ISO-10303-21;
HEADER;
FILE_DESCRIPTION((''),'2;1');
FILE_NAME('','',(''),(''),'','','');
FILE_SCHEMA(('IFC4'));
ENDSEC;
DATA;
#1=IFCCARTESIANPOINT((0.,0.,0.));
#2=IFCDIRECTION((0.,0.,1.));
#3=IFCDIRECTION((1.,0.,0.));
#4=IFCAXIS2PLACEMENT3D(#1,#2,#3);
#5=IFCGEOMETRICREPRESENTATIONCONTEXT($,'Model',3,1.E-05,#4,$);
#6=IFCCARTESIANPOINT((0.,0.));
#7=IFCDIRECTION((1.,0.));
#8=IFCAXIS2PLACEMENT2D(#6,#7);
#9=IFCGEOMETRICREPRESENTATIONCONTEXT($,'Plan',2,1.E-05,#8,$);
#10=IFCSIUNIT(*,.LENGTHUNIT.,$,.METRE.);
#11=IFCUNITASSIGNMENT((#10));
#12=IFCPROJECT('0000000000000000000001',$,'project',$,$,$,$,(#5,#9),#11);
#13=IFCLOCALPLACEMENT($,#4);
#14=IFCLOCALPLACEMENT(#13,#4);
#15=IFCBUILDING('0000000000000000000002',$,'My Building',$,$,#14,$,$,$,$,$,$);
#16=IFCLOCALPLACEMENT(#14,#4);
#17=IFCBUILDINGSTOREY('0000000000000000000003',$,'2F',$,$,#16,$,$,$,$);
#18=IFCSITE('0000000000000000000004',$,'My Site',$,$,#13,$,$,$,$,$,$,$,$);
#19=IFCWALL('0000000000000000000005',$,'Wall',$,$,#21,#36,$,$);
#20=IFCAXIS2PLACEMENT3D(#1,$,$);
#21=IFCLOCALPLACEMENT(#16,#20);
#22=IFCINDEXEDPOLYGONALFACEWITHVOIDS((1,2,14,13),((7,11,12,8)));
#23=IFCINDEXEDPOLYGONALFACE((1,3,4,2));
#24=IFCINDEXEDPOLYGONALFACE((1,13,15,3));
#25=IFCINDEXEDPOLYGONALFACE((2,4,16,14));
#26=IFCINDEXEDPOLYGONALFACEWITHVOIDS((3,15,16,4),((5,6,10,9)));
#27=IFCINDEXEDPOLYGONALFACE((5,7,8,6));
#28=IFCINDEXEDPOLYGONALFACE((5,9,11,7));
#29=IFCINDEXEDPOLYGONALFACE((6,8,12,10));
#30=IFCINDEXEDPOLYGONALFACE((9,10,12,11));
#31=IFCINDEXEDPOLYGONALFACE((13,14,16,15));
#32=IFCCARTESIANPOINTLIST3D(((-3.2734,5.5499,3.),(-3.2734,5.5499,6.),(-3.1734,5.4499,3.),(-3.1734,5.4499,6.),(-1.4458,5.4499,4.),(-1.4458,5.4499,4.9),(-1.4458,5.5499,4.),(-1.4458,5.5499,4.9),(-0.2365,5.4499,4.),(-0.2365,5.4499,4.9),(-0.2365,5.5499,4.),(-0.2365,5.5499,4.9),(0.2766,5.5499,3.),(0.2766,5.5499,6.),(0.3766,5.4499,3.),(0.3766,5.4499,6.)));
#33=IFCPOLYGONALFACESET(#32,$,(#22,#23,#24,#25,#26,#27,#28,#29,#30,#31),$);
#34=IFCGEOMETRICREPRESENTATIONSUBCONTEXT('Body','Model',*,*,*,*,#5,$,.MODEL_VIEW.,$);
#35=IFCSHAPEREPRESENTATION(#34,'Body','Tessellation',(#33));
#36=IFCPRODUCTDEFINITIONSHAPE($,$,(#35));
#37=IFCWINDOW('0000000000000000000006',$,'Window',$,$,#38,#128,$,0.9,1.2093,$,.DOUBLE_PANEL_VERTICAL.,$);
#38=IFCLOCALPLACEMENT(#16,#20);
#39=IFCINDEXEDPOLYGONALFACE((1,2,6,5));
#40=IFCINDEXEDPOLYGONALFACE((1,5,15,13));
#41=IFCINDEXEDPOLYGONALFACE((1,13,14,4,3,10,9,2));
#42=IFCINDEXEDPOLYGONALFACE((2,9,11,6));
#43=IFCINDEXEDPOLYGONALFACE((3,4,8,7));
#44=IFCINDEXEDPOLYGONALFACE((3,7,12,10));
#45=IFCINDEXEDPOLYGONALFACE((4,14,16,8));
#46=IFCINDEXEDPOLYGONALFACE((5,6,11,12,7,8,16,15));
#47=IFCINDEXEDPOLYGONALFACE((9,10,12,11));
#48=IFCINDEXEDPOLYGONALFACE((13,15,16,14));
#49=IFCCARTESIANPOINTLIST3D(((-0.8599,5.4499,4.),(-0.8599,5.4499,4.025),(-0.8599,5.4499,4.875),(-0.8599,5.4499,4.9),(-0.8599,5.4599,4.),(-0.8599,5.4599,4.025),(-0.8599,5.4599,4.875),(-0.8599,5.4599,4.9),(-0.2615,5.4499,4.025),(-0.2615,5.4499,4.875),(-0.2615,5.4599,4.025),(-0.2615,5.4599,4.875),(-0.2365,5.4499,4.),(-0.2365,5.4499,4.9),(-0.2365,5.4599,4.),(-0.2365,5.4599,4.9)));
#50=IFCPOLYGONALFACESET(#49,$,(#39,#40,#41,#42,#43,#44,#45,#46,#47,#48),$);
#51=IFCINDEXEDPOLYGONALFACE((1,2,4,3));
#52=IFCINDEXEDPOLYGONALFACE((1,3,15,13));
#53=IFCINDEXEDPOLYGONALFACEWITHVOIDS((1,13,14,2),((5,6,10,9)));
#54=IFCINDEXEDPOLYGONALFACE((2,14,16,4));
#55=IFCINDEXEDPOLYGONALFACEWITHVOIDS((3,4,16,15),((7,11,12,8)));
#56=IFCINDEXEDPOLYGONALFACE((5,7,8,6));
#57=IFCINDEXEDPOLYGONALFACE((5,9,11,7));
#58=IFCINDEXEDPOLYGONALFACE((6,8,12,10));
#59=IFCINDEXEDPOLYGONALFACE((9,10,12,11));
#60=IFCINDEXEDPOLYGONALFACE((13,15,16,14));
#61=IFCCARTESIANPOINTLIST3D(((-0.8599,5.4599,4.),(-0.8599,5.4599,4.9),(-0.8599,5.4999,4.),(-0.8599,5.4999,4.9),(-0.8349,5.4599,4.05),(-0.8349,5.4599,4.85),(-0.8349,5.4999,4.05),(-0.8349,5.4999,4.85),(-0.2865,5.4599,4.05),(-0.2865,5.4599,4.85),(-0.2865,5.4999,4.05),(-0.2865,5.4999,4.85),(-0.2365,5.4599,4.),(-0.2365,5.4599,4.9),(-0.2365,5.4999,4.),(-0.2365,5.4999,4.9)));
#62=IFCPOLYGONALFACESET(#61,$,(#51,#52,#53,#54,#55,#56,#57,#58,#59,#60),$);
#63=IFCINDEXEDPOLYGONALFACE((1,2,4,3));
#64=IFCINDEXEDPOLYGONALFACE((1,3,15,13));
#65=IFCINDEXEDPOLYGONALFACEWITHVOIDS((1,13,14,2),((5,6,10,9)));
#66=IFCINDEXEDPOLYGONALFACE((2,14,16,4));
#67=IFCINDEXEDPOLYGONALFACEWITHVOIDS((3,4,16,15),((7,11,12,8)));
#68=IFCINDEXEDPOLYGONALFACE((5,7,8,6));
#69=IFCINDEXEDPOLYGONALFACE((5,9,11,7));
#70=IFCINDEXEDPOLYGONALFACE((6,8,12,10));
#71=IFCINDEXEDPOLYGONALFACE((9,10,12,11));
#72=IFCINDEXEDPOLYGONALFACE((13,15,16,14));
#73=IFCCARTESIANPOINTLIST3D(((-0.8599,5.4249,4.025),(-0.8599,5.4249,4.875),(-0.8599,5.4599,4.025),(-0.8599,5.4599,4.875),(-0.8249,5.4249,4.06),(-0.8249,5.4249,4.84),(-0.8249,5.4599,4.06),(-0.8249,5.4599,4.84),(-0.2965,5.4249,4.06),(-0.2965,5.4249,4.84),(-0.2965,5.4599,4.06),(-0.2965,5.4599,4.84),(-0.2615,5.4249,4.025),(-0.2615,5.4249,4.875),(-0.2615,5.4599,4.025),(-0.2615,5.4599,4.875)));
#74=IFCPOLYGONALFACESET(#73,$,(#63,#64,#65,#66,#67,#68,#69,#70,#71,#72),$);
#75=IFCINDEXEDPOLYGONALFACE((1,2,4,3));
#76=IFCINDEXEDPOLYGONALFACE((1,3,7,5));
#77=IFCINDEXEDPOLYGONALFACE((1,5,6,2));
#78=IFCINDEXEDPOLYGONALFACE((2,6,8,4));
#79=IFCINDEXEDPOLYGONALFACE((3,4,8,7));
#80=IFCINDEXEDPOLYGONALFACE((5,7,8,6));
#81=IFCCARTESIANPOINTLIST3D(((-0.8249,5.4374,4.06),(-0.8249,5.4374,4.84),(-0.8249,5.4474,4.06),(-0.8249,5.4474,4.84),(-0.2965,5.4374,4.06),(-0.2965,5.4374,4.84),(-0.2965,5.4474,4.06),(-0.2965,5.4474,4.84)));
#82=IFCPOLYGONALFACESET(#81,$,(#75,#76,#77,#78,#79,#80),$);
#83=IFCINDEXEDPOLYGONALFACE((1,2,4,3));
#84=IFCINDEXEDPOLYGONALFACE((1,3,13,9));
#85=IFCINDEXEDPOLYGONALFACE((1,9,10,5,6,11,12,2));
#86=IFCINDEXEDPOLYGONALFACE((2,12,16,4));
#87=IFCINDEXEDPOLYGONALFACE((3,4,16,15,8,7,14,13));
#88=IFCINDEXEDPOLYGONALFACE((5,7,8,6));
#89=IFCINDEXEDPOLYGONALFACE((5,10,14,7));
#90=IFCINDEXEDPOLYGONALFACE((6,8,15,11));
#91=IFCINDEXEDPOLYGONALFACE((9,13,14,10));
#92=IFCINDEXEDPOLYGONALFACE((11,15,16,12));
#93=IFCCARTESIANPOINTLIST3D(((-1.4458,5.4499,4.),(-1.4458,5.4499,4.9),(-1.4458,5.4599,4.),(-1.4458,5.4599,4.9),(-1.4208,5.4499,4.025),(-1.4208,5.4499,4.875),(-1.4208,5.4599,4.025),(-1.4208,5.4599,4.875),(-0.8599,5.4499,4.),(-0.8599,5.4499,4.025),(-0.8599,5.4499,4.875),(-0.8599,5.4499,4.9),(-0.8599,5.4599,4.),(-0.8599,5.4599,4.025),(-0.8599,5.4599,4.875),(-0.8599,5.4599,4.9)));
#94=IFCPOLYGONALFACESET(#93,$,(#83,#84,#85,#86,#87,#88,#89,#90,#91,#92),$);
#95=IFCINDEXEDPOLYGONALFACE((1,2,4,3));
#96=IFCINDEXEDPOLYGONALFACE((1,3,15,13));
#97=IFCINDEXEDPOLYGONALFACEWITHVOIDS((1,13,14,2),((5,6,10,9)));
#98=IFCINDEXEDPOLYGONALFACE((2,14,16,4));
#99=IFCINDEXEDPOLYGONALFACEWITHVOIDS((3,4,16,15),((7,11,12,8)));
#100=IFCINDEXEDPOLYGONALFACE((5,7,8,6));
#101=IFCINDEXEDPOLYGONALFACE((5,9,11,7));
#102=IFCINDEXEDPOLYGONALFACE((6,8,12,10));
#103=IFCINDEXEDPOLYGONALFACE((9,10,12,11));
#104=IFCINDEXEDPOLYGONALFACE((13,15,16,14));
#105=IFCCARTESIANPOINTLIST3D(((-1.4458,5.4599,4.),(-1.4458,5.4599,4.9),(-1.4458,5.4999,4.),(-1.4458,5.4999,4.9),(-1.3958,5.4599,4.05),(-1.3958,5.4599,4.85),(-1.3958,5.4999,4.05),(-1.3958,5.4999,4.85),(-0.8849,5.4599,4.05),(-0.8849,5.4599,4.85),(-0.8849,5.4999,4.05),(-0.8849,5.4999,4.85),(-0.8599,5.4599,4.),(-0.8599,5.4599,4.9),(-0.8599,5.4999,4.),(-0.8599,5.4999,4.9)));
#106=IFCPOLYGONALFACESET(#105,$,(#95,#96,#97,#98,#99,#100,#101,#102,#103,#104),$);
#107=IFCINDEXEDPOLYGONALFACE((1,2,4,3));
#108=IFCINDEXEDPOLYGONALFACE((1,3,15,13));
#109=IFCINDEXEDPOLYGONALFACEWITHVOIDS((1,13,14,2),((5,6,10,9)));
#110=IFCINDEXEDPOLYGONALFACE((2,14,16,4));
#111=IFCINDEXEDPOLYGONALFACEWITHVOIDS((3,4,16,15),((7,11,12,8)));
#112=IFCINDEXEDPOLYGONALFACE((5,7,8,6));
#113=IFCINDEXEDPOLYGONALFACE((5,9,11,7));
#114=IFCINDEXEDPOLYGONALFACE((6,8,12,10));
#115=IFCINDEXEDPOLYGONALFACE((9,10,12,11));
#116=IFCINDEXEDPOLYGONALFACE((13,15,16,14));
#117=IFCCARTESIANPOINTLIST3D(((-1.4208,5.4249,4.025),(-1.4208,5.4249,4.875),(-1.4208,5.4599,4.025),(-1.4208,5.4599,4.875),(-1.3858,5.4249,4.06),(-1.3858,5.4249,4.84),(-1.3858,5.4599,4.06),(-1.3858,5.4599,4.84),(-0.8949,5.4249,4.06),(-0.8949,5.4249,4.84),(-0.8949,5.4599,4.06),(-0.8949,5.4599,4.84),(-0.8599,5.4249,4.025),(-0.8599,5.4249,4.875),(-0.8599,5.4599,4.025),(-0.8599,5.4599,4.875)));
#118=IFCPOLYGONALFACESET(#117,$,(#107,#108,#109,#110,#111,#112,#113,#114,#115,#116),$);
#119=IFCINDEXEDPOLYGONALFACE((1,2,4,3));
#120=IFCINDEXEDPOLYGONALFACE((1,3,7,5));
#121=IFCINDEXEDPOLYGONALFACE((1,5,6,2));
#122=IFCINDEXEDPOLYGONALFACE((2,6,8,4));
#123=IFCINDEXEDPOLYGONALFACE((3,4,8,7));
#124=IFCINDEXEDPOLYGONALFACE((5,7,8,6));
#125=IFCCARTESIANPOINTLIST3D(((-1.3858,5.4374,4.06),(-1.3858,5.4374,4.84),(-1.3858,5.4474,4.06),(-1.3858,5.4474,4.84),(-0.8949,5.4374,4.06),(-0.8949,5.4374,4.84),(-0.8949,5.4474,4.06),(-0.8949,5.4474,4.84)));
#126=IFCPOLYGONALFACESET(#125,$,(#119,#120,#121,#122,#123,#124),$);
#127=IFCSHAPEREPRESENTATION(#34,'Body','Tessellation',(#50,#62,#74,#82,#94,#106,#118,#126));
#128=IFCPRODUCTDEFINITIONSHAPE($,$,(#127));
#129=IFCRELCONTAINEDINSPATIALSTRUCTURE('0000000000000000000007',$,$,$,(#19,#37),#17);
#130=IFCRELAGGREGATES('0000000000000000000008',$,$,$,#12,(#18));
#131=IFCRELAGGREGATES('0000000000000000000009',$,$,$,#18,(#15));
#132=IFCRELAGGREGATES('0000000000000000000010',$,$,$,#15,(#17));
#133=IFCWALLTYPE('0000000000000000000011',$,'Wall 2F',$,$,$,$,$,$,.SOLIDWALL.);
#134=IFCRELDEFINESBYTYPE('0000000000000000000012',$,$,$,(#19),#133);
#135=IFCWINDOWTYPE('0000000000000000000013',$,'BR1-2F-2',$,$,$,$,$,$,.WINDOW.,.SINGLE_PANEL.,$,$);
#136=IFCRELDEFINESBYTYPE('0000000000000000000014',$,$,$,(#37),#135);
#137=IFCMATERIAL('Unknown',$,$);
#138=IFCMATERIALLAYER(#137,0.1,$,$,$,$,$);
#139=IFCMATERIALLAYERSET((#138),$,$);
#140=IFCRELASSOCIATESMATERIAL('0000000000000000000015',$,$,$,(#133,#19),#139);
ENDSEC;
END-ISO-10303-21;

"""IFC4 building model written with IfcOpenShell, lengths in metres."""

from ifc_helpers import new_model, entity, si_unit, frame, origin_with_axes, origin_2d_with_axis, place, context, subcontext, project, spatial, line, indexed_curve, outline, extrude, shape, source, transform, mapped, material, layer, layer_set, layer_usage, type_object, type_shapes, element, fill, save


model = new_model("IFC4")

# Units and contexts
model_context = context("Model", 3, precision=1e-05, world=origin_with_axes())
plan_context = context("Plan", 2, precision=1e-05, world=origin_2d_with_axis())
body_context_1 = subcontext(model_context, "Body", "Model", "MODEL_VIEW")
body_context_2 = subcontext(plan_context, "Body", "Plan", "PLAN_VIEW")
ifc_project = project(units=[si_unit("LENGTHUNIT", "METRE")], contexts=[model_context, plan_context])

# Site, building, storey
site_placement = place(None, origin_with_axes())
site = spatial("IfcSite", under=ifc_project, at=site_placement, Name="My Site")
building_placement = place(site_placement, origin_with_axes())
building = spatial("IfcBuilding", under=site, at=building_placement, Name="My Building")
storey_placement = place(building_placement, origin_with_axes())
storey = spatial("IfcBuildingStorey", under=building, at=storey_placement, Name="2F")

# Shared definitions
ifc_material = material(Name="Unknown")

# Shared definitions
ifc_layer_1 = layer(ifc_material, 0.1)
ifc_layer_set_1 = layer_set([ifc_layer_1])
wall_type = type_object("IfcWallType", Name="Wall 2F", PredefinedType="SOLIDWALL", material=ifc_layer_set_1)

# Wall, opening, window
ifc_layer_usage_1 = layer_usage(ifc_layer_set_1, "AXIS2", "POSITIVE", 0.0)
wall_1_placement = place(storey_placement, frame((0.2766, 5.5499, 3.0), z_axis=(0.0, 0.0, 1.0), x_axis=(-1.0, 0.0, 0.0)))
wall_1 = element("IfcWall", 1, at=wall_1_placement, inside=storey, type_object=wall_type, material=ifc_layer_usage_1, Name="Wall", context=body_context_1, shape_type="SweptSolid", body=[
    extrude(outline(indexed_curve([(0.0, 0.0), (-0.1, 0.1), (3.45, 0.1), (3.55, 0.0)], segments=[line(1, 2, 3, 4, 1)])), origin_with_axes(), (0.0, 0.0, 1.0), 3.0),
])
shared_shape_1 = source(origin_with_axes(), body_context_1, "Body", "SweptSolid", [
    extrude(outline(indexed_curve([(0.0, 0.0), (1.2093, 0.0), (1.2093, 0.9), (0.0, 0.9)], segments=[line(1, 2, 3, 4, 1)])), frame((0.0, -0.6, 0.0), z_axis=(0.0, -1.0, 0.0), x_axis=(1.0, 0.0, 0.0)), (0.0, 0.0, -1.0), 1.2),
])
opening_1_placement = place(wall_1_placement, frame((0.5131, 0.0, 1.0), z_axis=(0.0, 0.0, 1.0), x_axis=(1.0, 0.0, 0.0)))
opening_1 = element("IfcOpeningElement", 2, at=opening_1_placement, cuts=wall_1, PredefinedType="OPENING", context=body_context_1, shape_type="MappedRepresentation", body=[
    mapped(shared_shape_1, transform((0.0, 0.0, 0.0), x_axis=(1.0, 0.0, 0.0), y_axis=(0.0, 1.0, 0.0), z_axis=(0.0, 0.0, 1.0), scale=1.0)),
])
window_type_1 = type_object("IfcWindowType", Name="BR1-2F-2", PartitioningType="SINGLE_PANEL", PredefinedType="WINDOW")
shared_shape_2 = source(origin_with_axes(), body_context_1, "Body", "SweptSolid", [
    extrude(outline(indexed_curve([(0.6234, 0.0), (0.0, 0.0), (0.0, 0.9), (0.6234, 0.9), (0.6234, 0.875), (0.025, 0.875), (0.025, 0.025), (0.6234, 0.025)], segments=[line(1, 2, 3, 4, 5, 6, 7, 8, 1)])), frame((0.0, 0.09, 0.0), z_axis=(0.0, -1.0, 0.0), x_axis=(1.0, 0.0, 0.0)), (0.0, 0.0, -1.0), 0.01),
    extrude(outline(indexed_curve([(0.0, 0.0), (0.6234, 0.0), (0.6234, 0.9), (0.0, 0.9)], segments=[line(1, 2, 3, 4, 1)]), holes=[indexed_curve([(0.05, 0.05), (0.5984, 0.05), (0.5984, 0.85), (0.05, 0.85)], segments=[line(1, 2, 3, 4, 1)])]), frame((0.0, 0.05, 0.0), z_axis=(0.0, -1.0, 0.0), x_axis=(1.0, 0.0, 0.0)), (0.0, 0.0, -1.0), 0.04),
    extrude(outline(indexed_curve([(0.0, 0.0), (0.5984, 0.0), (0.5984, 0.85), (0.0, 0.85)], segments=[line(1, 2, 3, 4, 1)]), holes=[indexed_curve([(0.035, 0.035), (0.5634, 0.035), (0.5634, 0.815), (0.035, 0.815)], segments=[line(1, 2, 3, 4, 1)])]), frame((0.025, 0.09, 0.025), z_axis=(0.0, -1.0, 0.0), x_axis=(1.0, 0.0, 0.0)), (0.0, 0.0, -1.0), 0.035),
    extrude(outline(indexed_curve([(0.035, 0.035), (0.5634, 0.035), (0.5634, 0.815), (0.035, 0.815)], segments=[line(1, 2, 3, 4, 1)])), frame((0.025, 0.1025, 0.025), z_axis=(0.0, -1.0, 0.0), x_axis=(1.0, 0.0, 0.0)), (0.0, 0.0, -1.0), 0.01),
    extrude(outline(indexed_curve([(0.0, 0.9), (0.5859, 0.9), (0.5859, 0.0), (0.0, 0.0), (0.0, 0.025), (0.5609, 0.025), (0.5609, 0.875), (0.0, 0.875)], segments=[line(1, 2, 3, 4, 5, 6, 7, 8, 1)])), frame((0.6234, 0.09, 0.0), z_axis=(0.0, -1.0, 0.0), x_axis=(1.0, 0.0, 0.0)), (0.0, 0.0, -1.0), 0.01),
    extrude(outline(indexed_curve([(0.0, 0.0), (0.5859, 0.0), (0.5859, 0.9), (0.0, 0.9)], segments=[line(1, 2, 3, 4, 1)]), holes=[indexed_curve([(0.025, 0.05), (0.5359, 0.05), (0.5359, 0.85), (0.025, 0.85)], segments=[line(1, 2, 3, 4, 1)])]), frame((0.6234, 0.05, 0.0), z_axis=(0.0, -1.0, 0.0), x_axis=(1.0, 0.0, 0.0)), (0.0, 0.0, -1.0), 0.04),
    extrude(outline(indexed_curve([(0.0, 0.0), (0.5609, 0.0), (0.5609, 0.85), (0.0, 0.85)], segments=[line(1, 2, 3, 4, 1)]), holes=[indexed_curve([(0.035, 0.035), (0.5259, 0.035), (0.5259, 0.815), (0.035, 0.815)], segments=[line(1, 2, 3, 4, 1)])]), frame((0.6234, 0.09, 0.025), z_axis=(0.0, -1.0, 0.0), x_axis=(1.0, 0.0, 0.0)), (0.0, 0.0, -1.0), 0.035),
    extrude(outline(indexed_curve([(0.035, 0.035), (0.5259, 0.035), (0.5259, 0.815), (0.035, 0.815)], segments=[line(1, 2, 3, 4, 1)])), frame((0.6234, 0.1025, 0.025), z_axis=(0.0, -1.0, 0.0), x_axis=(1.0, 0.0, 0.0)), (0.0, 0.0, -1.0), 0.01),
])
shared_shape_3 = source(origin_with_axes(), body_context_2, "Body", "Curve2D", [
    entity("IfcIndexedPolyCurve", entity("IfcCartesianPointList2D", [[0.05, 0.05], [0.5984, 0.05]])),
    entity("IfcIndexedPolyCurve", entity("IfcCartesianPointList2D", [[0.0, 0.1], [0.025, 0.1], [0.025, 0.09], [0.05, 0.09], [0.05, 0.05], [0.0, 0.05]]), [entity("IfcLineIndex", [1, 2, 3, 4, 5, 6, 1])]),
    entity("IfcIndexedPolyCurve", entity("IfcCartesianPointList2D", [[0.6234, 0.1], [0.6234, 0.1], [0.6234, 0.09], [0.5984, 0.09], [0.5984, 0.05], [0.6234, 0.05]])),
    entity("IfcIndexedPolyCurve", entity("IfcCartesianPointList2D", [[0.025, 0.09], [0.06, 0.09], [0.06, 0.125], [0.025, 0.125]]), [entity("IfcLineIndex", [1, 2, 3, 4, 1])]),
    entity("IfcIndexedPolyCurve", entity("IfcCartesianPointList2D", [[0.6234, 0.09], [0.5884, 0.09], [0.5884, 0.125], [0.6234, 0.125]]), [entity("IfcLineIndex", [1, 2, 3, 4, 1])]),
    entity("IfcIndexedPolyCurve", entity("IfcCartesianPointList2D", [[0.06, 0.09], [0.5884, 0.09]])),
    entity("IfcIndexedPolyCurve", entity("IfcCartesianPointList2D", [[0.06, 0.125], [0.5884, 0.125]])),
    entity("IfcIndexedPolyCurve", entity("IfcCartesianPointList2D", [[0.06, 0.1075], [0.5884, 0.1075]])),
    entity("IfcIndexedPolyCurve", entity("IfcCartesianPointList2D", [[0.6484, 0.05], [1.1593, 0.05]])),
    entity("IfcIndexedPolyCurve", entity("IfcCartesianPointList2D", [[0.6234, 0.1], [0.6234, 0.1], [0.6234, 0.09], [0.6484, 0.09], [0.6484, 0.05], [0.6234, 0.05]])),
    entity("IfcIndexedPolyCurve", entity("IfcCartesianPointList2D", [[1.2093, 0.1], [1.1843, 0.1], [1.1843, 0.09], [1.1593, 0.09], [1.1593, 0.05], [1.2093, 0.05]]), [entity("IfcLineIndex", [1, 2, 3, 4, 5, 6, 1])]),
    entity("IfcIndexedPolyCurve", entity("IfcCartesianPointList2D", [[0.6234, 0.09], [0.6584, 0.09], [0.6584, 0.125], [0.6234, 0.125]]), [entity("IfcLineIndex", [1, 2, 3, 4, 1])]),
    entity("IfcIndexedPolyCurve", entity("IfcCartesianPointList2D", [[1.1843, 0.09], [1.1493, 0.09], [1.1493, 0.125], [1.1843, 0.125]]), [entity("IfcLineIndex", [1, 2, 3, 4, 1])]),
    entity("IfcIndexedPolyCurve", entity("IfcCartesianPointList2D", [[0.6584, 0.09], [1.1493, 0.09]])),
    entity("IfcIndexedPolyCurve", entity("IfcCartesianPointList2D", [[0.6584, 0.125], [1.1493, 0.125]])),
    entity("IfcIndexedPolyCurve", entity("IfcCartesianPointList2D", [[0.6584, 0.1075], [1.1493, 0.1075]])),
])
type_shapes(window_type_1, [shared_shape_2, shared_shape_3])
window_1_placement = place(opening_1_placement, frame((0.0, 0.0, 0.0), z_axis=(0.0, 0.0, 1.0), x_axis=(1.0, 0.0, 0.0)))
window_1 = element("IfcWindow", 3, at=window_1_placement, inside=storey, type_object=window_type_1, Name="Window", OverallHeight=0.9, OverallWidth=1.2093, PartitioningType="DOUBLE_PANEL_VERTICAL", shapes=[
    shape(body_context_1, "Body", "MappedRepresentation", [mapped(shared_shape_2, transform((0.0, 0.0, 0.0), x_axis=(1.0, 0.0, 0.0), y_axis=(0.0, 1.0, 0.0), z_axis=(0.0, 0.0, 1.0), scale=1.0))]),
    shape(body_context_2, "Body", "MappedRepresentation", [mapped(shared_shape_3, transform((0.0, 0.0, 0.0), x_axis=(1.0, 0.0, 0.0), y_axis=(0.0, 1.0, 0.0), z_axis=(0.0, 0.0, 1.0), scale=1.0))]),
])
fill(opening_1, window_1)

save(model, "model.ifc")
